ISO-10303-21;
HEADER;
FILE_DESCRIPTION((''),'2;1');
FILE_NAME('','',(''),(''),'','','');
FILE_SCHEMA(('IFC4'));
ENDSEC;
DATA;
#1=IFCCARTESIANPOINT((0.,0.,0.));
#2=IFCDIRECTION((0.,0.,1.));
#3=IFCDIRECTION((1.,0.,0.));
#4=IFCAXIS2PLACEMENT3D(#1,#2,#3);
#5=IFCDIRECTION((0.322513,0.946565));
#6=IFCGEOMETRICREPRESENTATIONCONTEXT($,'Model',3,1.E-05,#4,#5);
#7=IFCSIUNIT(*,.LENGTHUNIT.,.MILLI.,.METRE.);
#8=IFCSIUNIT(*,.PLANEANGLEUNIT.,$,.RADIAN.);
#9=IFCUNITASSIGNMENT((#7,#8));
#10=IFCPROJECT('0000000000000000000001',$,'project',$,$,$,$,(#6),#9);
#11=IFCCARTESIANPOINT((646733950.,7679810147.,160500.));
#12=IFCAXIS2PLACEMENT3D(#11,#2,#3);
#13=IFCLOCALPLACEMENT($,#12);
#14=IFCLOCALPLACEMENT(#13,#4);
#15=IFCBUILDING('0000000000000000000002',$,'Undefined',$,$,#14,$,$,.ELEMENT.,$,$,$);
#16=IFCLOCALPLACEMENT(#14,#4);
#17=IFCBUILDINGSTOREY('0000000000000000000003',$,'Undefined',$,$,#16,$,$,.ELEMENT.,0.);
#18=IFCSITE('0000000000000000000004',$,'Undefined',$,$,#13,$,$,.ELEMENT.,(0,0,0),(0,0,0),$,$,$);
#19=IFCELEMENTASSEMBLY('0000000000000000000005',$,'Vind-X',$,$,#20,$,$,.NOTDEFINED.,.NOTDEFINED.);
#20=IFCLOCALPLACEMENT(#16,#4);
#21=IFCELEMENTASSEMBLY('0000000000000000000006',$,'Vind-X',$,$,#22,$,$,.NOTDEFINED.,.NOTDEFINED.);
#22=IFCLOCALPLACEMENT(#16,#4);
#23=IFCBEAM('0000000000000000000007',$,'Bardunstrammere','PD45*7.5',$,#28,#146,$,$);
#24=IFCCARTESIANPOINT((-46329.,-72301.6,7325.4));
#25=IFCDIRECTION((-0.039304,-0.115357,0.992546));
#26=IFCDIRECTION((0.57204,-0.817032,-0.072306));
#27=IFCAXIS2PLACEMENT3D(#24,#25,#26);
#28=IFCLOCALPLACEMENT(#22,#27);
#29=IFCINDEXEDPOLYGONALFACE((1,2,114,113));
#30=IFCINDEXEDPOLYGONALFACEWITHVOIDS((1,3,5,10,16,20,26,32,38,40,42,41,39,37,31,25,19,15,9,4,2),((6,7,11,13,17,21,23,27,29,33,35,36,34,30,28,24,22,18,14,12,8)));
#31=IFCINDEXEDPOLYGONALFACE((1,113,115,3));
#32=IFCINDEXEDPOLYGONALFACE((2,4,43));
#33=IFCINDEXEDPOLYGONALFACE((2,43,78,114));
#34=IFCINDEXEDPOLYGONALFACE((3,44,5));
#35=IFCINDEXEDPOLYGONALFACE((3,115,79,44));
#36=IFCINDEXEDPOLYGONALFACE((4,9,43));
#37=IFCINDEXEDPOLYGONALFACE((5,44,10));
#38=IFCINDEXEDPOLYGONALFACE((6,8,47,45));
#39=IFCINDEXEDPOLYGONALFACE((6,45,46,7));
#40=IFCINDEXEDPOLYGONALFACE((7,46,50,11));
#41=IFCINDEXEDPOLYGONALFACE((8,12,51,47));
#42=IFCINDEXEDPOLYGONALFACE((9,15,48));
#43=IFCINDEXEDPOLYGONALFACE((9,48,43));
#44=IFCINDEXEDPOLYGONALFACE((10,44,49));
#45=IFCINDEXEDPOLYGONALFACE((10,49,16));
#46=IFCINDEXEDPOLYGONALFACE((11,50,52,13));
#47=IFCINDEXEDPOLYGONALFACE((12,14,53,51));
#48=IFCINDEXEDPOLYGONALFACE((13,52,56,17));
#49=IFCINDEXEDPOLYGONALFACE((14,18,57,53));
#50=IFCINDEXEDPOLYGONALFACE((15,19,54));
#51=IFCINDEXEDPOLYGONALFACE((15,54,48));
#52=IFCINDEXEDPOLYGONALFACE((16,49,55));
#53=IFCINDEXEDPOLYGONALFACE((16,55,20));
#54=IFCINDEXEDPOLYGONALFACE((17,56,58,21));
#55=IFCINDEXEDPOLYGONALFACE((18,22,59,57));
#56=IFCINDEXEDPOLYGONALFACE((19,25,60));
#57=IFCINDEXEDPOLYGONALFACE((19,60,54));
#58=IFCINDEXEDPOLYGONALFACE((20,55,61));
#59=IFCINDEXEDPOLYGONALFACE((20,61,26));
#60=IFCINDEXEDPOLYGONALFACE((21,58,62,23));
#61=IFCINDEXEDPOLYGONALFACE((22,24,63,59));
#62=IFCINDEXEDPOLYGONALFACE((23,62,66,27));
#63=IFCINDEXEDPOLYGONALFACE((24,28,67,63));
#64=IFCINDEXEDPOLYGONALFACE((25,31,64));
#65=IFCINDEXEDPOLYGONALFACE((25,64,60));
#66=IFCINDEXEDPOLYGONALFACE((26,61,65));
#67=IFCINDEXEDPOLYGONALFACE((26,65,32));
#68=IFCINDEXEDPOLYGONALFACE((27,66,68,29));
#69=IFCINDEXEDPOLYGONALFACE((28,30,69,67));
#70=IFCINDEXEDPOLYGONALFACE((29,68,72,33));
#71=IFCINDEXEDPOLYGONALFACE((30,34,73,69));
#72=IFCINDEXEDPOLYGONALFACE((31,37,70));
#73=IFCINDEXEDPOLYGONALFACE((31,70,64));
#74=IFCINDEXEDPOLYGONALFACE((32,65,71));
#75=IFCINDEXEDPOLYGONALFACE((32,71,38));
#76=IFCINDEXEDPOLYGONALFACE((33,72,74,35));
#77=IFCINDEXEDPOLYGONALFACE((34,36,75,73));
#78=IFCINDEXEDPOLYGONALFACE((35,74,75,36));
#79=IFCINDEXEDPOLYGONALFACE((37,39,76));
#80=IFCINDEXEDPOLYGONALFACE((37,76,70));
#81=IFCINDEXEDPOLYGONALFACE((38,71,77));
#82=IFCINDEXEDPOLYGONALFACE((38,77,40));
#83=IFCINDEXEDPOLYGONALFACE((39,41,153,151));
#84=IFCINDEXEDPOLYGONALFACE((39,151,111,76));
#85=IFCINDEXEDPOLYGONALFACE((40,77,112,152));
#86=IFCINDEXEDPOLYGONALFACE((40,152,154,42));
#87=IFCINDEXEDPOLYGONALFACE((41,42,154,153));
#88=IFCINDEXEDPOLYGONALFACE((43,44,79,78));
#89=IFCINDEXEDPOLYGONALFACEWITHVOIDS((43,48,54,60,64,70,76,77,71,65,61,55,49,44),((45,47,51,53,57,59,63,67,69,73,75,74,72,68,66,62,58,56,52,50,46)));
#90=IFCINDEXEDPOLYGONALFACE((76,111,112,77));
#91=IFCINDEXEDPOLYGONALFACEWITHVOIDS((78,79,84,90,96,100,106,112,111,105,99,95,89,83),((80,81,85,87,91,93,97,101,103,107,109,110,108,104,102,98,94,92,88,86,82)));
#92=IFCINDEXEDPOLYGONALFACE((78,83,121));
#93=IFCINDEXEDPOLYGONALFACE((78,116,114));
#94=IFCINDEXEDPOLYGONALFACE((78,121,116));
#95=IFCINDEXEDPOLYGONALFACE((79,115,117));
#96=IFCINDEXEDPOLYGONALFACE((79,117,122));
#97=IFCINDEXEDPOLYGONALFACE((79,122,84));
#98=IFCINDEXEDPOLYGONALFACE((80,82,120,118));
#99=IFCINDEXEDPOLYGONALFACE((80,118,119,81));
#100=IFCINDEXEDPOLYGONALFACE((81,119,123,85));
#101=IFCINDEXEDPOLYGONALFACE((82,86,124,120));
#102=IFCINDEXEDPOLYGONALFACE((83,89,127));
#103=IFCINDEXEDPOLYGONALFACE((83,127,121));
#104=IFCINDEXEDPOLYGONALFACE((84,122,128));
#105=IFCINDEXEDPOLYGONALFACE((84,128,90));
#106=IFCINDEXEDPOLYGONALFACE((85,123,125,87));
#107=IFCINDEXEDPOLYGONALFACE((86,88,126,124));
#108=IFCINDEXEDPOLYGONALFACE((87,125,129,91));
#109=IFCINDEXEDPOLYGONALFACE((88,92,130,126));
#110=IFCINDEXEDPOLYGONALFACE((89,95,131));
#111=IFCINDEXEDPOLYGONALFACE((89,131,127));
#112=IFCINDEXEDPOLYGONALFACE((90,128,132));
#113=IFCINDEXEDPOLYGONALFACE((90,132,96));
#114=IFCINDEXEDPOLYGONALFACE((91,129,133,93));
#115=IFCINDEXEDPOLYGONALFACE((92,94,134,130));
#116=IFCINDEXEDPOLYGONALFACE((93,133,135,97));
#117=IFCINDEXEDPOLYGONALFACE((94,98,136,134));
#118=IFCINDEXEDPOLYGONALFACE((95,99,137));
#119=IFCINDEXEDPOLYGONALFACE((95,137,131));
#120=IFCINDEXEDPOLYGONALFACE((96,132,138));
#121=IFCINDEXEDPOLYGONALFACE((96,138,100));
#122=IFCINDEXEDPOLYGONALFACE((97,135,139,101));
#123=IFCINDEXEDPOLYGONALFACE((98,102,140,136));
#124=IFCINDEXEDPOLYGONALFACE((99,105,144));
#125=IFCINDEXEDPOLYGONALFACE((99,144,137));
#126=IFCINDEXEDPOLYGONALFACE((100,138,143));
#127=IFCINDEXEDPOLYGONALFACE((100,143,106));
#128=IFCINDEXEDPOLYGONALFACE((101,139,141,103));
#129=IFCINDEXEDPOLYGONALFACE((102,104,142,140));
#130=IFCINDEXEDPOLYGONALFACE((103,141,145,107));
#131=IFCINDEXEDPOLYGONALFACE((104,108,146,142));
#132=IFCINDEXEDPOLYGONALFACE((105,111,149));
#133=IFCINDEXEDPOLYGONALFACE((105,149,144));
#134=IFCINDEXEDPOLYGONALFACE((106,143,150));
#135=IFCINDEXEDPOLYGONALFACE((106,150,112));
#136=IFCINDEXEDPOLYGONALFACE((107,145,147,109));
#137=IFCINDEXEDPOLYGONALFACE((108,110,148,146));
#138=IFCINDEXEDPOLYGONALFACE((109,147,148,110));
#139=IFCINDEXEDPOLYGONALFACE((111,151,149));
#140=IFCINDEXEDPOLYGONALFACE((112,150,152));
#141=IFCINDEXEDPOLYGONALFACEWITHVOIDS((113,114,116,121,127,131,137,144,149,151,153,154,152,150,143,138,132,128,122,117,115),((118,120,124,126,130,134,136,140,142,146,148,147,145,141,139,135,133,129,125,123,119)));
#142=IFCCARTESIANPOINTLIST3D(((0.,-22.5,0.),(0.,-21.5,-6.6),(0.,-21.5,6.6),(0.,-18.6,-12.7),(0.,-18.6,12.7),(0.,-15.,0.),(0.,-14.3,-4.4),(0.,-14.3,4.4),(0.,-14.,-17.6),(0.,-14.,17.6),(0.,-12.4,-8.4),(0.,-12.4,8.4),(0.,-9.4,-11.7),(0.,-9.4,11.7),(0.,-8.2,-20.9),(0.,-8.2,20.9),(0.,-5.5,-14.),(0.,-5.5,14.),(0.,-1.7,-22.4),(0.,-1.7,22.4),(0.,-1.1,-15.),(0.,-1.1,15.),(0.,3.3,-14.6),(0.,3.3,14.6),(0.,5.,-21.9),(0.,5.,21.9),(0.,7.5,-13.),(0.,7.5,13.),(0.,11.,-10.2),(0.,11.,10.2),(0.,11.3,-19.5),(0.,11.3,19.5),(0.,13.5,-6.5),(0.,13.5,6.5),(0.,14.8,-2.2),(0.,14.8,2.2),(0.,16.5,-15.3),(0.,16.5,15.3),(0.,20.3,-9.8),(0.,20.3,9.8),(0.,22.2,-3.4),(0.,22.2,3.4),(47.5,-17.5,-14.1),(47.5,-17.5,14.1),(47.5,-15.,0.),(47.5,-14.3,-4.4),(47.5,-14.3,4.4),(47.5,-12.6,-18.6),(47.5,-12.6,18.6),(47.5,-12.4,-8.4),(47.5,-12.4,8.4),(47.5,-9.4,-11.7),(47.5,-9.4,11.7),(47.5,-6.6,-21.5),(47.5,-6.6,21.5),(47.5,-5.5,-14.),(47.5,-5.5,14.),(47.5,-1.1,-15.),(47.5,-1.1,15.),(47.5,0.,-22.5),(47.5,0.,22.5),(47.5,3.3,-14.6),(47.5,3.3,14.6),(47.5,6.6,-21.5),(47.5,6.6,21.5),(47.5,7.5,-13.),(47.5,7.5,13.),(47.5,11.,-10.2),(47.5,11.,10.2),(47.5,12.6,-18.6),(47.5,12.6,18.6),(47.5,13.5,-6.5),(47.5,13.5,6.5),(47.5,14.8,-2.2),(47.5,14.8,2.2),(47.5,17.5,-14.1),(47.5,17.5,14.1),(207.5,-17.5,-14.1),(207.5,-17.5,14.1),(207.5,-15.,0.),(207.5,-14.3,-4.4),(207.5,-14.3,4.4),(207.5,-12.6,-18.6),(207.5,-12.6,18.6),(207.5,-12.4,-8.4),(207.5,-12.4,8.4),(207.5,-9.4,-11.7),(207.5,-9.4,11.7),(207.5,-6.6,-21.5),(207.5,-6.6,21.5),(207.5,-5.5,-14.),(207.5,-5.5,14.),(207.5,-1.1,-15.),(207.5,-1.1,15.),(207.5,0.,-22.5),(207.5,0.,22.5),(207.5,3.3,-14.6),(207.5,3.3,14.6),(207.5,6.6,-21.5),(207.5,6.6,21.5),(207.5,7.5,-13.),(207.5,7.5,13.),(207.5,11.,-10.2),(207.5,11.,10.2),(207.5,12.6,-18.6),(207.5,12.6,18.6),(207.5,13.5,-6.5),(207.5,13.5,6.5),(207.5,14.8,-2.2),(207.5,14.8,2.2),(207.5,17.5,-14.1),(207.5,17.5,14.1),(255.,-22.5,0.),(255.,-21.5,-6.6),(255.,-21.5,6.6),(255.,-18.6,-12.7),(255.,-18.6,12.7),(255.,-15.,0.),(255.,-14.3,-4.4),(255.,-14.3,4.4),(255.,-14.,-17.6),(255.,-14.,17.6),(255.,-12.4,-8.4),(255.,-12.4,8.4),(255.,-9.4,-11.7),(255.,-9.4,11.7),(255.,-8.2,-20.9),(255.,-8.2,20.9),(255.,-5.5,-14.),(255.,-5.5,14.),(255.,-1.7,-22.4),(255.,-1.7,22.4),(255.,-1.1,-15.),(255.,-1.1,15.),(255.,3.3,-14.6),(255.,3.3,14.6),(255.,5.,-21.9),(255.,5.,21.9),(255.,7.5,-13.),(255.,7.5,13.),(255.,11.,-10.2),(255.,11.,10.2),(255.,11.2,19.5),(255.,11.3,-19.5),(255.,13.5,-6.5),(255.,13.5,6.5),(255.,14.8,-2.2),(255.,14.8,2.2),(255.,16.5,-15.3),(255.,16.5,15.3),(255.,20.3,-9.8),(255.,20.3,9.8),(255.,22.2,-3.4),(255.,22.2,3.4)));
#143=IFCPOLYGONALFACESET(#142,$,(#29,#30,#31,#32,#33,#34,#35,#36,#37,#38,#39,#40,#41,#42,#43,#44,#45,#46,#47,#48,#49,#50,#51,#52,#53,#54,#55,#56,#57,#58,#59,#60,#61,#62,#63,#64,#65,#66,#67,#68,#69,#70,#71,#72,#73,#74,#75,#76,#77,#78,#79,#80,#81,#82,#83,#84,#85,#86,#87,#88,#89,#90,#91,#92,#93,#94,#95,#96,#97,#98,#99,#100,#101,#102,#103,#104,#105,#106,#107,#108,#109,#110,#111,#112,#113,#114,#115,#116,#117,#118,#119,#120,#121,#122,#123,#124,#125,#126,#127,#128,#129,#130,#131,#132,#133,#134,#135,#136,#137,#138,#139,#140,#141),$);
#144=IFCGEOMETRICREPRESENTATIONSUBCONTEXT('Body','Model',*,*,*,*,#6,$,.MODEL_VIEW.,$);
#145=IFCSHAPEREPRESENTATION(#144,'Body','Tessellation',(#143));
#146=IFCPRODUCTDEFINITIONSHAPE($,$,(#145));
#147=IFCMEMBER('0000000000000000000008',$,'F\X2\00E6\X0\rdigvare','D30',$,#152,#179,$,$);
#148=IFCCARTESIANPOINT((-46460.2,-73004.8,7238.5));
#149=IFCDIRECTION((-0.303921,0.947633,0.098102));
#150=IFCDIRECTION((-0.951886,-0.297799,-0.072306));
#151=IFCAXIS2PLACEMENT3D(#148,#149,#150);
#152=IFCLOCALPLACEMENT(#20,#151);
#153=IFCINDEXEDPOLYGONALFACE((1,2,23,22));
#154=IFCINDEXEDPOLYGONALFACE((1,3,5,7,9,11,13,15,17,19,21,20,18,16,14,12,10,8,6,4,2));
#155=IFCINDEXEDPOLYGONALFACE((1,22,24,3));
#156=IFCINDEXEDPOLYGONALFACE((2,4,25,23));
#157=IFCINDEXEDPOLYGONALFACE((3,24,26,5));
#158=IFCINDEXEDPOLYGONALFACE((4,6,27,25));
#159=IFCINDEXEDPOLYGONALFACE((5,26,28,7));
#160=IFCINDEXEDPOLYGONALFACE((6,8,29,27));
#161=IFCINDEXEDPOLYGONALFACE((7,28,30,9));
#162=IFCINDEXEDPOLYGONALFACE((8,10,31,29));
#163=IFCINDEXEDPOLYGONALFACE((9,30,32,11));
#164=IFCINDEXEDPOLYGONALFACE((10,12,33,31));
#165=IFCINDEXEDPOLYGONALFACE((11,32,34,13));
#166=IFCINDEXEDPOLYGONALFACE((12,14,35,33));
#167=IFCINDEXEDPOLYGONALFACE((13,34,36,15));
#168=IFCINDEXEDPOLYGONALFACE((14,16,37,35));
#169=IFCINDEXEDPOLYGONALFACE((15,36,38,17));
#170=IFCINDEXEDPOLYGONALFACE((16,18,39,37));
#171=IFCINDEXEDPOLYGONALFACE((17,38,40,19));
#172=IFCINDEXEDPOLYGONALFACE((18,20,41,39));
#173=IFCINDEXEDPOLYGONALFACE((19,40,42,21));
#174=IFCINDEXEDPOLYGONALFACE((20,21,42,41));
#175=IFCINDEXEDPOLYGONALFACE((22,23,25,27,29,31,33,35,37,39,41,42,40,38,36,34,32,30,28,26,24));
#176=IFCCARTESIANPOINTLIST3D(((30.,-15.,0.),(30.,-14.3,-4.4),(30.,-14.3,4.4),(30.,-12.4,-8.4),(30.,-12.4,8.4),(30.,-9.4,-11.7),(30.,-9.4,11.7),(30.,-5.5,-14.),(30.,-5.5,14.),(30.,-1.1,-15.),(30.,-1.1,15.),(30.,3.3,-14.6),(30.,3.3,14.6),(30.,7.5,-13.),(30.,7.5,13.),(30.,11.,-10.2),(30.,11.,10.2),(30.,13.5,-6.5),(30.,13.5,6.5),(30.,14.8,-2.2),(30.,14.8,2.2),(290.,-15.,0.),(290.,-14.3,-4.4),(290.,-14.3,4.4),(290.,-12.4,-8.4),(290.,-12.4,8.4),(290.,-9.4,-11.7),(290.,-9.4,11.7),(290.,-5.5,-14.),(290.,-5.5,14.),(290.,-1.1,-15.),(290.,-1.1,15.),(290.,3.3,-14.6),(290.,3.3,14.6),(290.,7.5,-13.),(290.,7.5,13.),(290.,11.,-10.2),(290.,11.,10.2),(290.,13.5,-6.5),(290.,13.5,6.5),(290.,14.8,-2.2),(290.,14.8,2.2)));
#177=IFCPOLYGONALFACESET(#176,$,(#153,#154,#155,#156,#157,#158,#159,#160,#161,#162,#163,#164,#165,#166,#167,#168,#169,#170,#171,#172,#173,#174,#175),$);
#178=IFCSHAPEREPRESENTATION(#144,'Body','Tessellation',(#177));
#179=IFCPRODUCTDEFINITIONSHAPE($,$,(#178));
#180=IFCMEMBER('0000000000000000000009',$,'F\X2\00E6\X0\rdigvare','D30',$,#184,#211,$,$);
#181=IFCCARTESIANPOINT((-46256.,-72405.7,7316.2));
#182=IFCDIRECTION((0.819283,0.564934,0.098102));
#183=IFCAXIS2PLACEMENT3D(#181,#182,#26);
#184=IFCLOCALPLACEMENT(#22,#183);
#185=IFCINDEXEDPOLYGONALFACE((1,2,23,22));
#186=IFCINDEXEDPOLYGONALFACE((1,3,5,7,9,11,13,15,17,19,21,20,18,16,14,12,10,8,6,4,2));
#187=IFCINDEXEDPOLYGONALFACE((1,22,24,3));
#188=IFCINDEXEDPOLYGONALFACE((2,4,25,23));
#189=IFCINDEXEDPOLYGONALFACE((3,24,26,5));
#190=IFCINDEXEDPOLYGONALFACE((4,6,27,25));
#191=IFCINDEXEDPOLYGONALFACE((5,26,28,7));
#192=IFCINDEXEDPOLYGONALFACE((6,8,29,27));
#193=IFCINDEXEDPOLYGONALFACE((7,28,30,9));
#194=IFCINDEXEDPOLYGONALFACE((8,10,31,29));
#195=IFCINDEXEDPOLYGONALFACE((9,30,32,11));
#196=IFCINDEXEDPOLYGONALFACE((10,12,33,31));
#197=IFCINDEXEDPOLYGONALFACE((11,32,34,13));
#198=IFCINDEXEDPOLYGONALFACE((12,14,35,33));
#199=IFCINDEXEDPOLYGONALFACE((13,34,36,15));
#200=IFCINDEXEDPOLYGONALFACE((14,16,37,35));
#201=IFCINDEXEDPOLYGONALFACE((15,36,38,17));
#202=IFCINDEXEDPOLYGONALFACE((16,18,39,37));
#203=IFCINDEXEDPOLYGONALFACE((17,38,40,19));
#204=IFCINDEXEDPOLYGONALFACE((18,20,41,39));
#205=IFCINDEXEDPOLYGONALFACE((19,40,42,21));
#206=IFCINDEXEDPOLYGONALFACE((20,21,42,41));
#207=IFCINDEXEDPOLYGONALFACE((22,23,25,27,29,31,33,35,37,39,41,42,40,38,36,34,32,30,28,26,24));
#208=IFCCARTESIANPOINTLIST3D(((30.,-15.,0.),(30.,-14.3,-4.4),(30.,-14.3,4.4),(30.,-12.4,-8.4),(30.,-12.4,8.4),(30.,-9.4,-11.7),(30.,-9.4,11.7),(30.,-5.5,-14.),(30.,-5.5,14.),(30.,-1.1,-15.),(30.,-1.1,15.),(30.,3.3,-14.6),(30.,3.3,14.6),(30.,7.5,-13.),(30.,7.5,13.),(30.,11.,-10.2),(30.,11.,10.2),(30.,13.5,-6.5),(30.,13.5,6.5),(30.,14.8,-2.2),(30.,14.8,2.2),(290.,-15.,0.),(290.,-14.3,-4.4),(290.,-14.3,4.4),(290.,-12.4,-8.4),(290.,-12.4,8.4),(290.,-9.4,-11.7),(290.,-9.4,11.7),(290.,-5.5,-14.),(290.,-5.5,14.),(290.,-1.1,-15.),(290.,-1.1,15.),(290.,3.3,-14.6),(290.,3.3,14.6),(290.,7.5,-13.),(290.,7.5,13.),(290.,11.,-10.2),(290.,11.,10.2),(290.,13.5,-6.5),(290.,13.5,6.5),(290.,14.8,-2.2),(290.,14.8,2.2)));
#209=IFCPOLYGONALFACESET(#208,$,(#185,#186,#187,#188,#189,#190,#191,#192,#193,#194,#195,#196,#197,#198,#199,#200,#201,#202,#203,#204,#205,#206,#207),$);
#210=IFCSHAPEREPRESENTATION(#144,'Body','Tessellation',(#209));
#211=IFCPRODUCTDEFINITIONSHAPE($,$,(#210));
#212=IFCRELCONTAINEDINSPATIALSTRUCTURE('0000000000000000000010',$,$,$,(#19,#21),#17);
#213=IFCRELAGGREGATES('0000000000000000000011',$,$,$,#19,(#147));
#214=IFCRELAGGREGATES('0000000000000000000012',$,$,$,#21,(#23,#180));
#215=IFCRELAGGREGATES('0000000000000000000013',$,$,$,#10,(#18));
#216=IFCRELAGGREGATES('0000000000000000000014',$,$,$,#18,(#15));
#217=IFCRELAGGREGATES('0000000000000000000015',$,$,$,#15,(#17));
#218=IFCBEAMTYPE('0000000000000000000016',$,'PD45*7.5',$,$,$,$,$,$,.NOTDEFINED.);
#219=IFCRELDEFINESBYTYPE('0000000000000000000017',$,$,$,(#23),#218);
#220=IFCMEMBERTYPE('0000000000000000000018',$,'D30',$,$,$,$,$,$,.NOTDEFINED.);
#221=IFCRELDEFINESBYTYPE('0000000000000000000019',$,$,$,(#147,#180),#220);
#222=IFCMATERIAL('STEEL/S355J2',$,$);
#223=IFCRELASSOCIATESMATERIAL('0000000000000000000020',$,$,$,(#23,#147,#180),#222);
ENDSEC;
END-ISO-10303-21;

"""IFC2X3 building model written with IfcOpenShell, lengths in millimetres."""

from ifc_helpers import new_model, si_unit, direction, frame, origin_with_axes, origin_2d_with_axis, place, context, subcontext, project, spatial, rectangle, circle, hollow_circle, extrude, boolean, clip, halfspace, material, type_object, element, aggregate, save


model = new_model("IFC2X3")

# Units and contexts
model_context = context("Model", 3, precision=1e-05, world=origin_with_axes(), true_north=direction((0.322513, 0.946565)))
body_context = subcontext(model_context, "Body", "Model", "MODEL_VIEW")
ifc_project = project(units=[si_unit("LENGTHUNIT", "METRE", prefix="MILLI"), si_unit("PLANEANGLEUNIT", "RADIAN")], contexts=[model_context])

# Site, building, storey
site_placement = place(None, frame((646733950.0, 7679810147.0, 160500.0), z_axis=(0.0, 0.0, 1.0), x_axis=(1.0, 0.0, 0.0)))
site = spatial("IfcSite", under=ifc_project, at=site_placement, Name="Undefined", CompositionType="ELEMENT", RefLatitude=(0, 0, 0), RefLongitude=(0, 0, 0))
building_placement = place(site_placement, origin_with_axes())
building = spatial("IfcBuilding", under=site, at=building_placement, Name="Undefined", CompositionType="ELEMENT")
storey_placement = place(building_placement, origin_with_axes())
storey = spatial("IfcBuildingStorey", under=building, at=storey_placement, Name="Undefined", CompositionType="ELEMENT", Elevation=0.0)

# Element assemblies, beam
assembly_1_placement = place(storey_placement, origin_with_axes())
assembly_1 = element("IfcElementAssembly", 1, at=assembly_1_placement, inside=storey, Name="Vind-X", AssemblyPlace="NOTDEFINED", PredefinedType="NOTDEFINED")
ifc_material_1 = material(Name="STEEL/S355J2")
beam_type = type_object("IfcBeamType", Name="PD45*7.5", PredefinedType="NOTDEFINED")
assembly_2_placement = place(storey_placement, origin_with_axes())
assembly_2 = element("IfcElementAssembly", 2, at=assembly_2_placement, inside=storey, Name="Vind-X", AssemblyPlace="NOTDEFINED", PredefinedType="NOTDEFINED")
beam_1_placement = place(assembly_2_placement, frame((-46329.0, -72301.6, 7325.4), z_axis=(-0.039304, -0.115357, 0.992546), x_axis=(0.57204, -0.817032, -0.072306)))
beam_1 = element("IfcBeam", 3, at=beam_1_placement, type_object=beam_type, material=ifc_material_1, Name="Bardunstrammere", Description="PD45*7.5", context=body_context, shape_type="CSG", body=[
    boolean("DIFFERENCE", extrude(hollow_circle(Radius=22.5, WallThickness=7.5, at=origin_2d_with_axis()), frame((255.0, 0.0, 0.0), z_axis=(-1.0, 0.0, 0.0), x_axis=(0.0, -1.0, 0.0)), (0.0, 0.0, 1.0), 255.0), extrude(rectangle(XDim=35.0, YDim=90.0, at=origin_2d_with_axis()), frame((207.5, 0.0, 0.0), z_axis=(-1.0, 0.0, 0.0), x_axis=(0.0, -1.0, 0.0)), (0.0, 0.0, 1.0), 160.0)),
])

# Members
member_type = type_object("IfcMemberType", Name="D30", PredefinedType="NOTDEFINED")
member_1_placement = place(assembly_1_placement, frame((-46460.2, -73004.8, 7238.5), z_axis=(-0.303921, 0.947633, 0.098102), x_axis=(-0.951886, -0.297799, -0.072306)))
member_1 = element("IfcMember", 4, at=member_1_placement, type_object=member_type, material=ifc_material_1, Name="Færdigvare", Description="D30", context=body_context, shape_type="Clipping", body=[
    clip(extrude(circle(Radius=15.0, at=origin_2d_with_axis()), frame((290.0, 0.0, 0.0), z_axis=(-1.0, 0.0, 0.0), x_axis=(0.0, -1.0, 0.0)), (0.0, 0.0, 1.0), 290.0), halfspace(frame((30.0, 0.0, -15.0), z_axis=(1.0, 0.0, 0.0), x_axis=(0.0, -1.0, 0.0)), True)),
])
member_2_placement = place(assembly_2_placement, frame((-46256.0, -72405.7, 7316.2), z_axis=(0.819283, 0.564934, 0.098102), x_axis=(0.57204, -0.817032, -0.072306)))
member_2 = element("IfcMember", 5, at=member_2_placement, type_object=member_type, material=ifc_material_1, Name="Færdigvare", Description="D30", context=body_context, shape_type="Clipping", body=[
    clip(extrude(circle(Radius=15.0, at=origin_2d_with_axis()), frame((290.0, 0.0, 0.0), z_axis=(-1.0, 0.0, 0.0), x_axis=(0.0, -1.0, 0.0)), (0.0, 0.0, 1.0), 290.4), halfspace(frame((30.0, 0.0, -15.0), z_axis=(1.0, 0.0, 0.0), x_axis=(0.0, -1.0, 0.0)), True)),
])

aggregate(assembly_1, [member_1])
aggregate(assembly_2, [beam_1, member_2])

save(model, "model.ifc")
